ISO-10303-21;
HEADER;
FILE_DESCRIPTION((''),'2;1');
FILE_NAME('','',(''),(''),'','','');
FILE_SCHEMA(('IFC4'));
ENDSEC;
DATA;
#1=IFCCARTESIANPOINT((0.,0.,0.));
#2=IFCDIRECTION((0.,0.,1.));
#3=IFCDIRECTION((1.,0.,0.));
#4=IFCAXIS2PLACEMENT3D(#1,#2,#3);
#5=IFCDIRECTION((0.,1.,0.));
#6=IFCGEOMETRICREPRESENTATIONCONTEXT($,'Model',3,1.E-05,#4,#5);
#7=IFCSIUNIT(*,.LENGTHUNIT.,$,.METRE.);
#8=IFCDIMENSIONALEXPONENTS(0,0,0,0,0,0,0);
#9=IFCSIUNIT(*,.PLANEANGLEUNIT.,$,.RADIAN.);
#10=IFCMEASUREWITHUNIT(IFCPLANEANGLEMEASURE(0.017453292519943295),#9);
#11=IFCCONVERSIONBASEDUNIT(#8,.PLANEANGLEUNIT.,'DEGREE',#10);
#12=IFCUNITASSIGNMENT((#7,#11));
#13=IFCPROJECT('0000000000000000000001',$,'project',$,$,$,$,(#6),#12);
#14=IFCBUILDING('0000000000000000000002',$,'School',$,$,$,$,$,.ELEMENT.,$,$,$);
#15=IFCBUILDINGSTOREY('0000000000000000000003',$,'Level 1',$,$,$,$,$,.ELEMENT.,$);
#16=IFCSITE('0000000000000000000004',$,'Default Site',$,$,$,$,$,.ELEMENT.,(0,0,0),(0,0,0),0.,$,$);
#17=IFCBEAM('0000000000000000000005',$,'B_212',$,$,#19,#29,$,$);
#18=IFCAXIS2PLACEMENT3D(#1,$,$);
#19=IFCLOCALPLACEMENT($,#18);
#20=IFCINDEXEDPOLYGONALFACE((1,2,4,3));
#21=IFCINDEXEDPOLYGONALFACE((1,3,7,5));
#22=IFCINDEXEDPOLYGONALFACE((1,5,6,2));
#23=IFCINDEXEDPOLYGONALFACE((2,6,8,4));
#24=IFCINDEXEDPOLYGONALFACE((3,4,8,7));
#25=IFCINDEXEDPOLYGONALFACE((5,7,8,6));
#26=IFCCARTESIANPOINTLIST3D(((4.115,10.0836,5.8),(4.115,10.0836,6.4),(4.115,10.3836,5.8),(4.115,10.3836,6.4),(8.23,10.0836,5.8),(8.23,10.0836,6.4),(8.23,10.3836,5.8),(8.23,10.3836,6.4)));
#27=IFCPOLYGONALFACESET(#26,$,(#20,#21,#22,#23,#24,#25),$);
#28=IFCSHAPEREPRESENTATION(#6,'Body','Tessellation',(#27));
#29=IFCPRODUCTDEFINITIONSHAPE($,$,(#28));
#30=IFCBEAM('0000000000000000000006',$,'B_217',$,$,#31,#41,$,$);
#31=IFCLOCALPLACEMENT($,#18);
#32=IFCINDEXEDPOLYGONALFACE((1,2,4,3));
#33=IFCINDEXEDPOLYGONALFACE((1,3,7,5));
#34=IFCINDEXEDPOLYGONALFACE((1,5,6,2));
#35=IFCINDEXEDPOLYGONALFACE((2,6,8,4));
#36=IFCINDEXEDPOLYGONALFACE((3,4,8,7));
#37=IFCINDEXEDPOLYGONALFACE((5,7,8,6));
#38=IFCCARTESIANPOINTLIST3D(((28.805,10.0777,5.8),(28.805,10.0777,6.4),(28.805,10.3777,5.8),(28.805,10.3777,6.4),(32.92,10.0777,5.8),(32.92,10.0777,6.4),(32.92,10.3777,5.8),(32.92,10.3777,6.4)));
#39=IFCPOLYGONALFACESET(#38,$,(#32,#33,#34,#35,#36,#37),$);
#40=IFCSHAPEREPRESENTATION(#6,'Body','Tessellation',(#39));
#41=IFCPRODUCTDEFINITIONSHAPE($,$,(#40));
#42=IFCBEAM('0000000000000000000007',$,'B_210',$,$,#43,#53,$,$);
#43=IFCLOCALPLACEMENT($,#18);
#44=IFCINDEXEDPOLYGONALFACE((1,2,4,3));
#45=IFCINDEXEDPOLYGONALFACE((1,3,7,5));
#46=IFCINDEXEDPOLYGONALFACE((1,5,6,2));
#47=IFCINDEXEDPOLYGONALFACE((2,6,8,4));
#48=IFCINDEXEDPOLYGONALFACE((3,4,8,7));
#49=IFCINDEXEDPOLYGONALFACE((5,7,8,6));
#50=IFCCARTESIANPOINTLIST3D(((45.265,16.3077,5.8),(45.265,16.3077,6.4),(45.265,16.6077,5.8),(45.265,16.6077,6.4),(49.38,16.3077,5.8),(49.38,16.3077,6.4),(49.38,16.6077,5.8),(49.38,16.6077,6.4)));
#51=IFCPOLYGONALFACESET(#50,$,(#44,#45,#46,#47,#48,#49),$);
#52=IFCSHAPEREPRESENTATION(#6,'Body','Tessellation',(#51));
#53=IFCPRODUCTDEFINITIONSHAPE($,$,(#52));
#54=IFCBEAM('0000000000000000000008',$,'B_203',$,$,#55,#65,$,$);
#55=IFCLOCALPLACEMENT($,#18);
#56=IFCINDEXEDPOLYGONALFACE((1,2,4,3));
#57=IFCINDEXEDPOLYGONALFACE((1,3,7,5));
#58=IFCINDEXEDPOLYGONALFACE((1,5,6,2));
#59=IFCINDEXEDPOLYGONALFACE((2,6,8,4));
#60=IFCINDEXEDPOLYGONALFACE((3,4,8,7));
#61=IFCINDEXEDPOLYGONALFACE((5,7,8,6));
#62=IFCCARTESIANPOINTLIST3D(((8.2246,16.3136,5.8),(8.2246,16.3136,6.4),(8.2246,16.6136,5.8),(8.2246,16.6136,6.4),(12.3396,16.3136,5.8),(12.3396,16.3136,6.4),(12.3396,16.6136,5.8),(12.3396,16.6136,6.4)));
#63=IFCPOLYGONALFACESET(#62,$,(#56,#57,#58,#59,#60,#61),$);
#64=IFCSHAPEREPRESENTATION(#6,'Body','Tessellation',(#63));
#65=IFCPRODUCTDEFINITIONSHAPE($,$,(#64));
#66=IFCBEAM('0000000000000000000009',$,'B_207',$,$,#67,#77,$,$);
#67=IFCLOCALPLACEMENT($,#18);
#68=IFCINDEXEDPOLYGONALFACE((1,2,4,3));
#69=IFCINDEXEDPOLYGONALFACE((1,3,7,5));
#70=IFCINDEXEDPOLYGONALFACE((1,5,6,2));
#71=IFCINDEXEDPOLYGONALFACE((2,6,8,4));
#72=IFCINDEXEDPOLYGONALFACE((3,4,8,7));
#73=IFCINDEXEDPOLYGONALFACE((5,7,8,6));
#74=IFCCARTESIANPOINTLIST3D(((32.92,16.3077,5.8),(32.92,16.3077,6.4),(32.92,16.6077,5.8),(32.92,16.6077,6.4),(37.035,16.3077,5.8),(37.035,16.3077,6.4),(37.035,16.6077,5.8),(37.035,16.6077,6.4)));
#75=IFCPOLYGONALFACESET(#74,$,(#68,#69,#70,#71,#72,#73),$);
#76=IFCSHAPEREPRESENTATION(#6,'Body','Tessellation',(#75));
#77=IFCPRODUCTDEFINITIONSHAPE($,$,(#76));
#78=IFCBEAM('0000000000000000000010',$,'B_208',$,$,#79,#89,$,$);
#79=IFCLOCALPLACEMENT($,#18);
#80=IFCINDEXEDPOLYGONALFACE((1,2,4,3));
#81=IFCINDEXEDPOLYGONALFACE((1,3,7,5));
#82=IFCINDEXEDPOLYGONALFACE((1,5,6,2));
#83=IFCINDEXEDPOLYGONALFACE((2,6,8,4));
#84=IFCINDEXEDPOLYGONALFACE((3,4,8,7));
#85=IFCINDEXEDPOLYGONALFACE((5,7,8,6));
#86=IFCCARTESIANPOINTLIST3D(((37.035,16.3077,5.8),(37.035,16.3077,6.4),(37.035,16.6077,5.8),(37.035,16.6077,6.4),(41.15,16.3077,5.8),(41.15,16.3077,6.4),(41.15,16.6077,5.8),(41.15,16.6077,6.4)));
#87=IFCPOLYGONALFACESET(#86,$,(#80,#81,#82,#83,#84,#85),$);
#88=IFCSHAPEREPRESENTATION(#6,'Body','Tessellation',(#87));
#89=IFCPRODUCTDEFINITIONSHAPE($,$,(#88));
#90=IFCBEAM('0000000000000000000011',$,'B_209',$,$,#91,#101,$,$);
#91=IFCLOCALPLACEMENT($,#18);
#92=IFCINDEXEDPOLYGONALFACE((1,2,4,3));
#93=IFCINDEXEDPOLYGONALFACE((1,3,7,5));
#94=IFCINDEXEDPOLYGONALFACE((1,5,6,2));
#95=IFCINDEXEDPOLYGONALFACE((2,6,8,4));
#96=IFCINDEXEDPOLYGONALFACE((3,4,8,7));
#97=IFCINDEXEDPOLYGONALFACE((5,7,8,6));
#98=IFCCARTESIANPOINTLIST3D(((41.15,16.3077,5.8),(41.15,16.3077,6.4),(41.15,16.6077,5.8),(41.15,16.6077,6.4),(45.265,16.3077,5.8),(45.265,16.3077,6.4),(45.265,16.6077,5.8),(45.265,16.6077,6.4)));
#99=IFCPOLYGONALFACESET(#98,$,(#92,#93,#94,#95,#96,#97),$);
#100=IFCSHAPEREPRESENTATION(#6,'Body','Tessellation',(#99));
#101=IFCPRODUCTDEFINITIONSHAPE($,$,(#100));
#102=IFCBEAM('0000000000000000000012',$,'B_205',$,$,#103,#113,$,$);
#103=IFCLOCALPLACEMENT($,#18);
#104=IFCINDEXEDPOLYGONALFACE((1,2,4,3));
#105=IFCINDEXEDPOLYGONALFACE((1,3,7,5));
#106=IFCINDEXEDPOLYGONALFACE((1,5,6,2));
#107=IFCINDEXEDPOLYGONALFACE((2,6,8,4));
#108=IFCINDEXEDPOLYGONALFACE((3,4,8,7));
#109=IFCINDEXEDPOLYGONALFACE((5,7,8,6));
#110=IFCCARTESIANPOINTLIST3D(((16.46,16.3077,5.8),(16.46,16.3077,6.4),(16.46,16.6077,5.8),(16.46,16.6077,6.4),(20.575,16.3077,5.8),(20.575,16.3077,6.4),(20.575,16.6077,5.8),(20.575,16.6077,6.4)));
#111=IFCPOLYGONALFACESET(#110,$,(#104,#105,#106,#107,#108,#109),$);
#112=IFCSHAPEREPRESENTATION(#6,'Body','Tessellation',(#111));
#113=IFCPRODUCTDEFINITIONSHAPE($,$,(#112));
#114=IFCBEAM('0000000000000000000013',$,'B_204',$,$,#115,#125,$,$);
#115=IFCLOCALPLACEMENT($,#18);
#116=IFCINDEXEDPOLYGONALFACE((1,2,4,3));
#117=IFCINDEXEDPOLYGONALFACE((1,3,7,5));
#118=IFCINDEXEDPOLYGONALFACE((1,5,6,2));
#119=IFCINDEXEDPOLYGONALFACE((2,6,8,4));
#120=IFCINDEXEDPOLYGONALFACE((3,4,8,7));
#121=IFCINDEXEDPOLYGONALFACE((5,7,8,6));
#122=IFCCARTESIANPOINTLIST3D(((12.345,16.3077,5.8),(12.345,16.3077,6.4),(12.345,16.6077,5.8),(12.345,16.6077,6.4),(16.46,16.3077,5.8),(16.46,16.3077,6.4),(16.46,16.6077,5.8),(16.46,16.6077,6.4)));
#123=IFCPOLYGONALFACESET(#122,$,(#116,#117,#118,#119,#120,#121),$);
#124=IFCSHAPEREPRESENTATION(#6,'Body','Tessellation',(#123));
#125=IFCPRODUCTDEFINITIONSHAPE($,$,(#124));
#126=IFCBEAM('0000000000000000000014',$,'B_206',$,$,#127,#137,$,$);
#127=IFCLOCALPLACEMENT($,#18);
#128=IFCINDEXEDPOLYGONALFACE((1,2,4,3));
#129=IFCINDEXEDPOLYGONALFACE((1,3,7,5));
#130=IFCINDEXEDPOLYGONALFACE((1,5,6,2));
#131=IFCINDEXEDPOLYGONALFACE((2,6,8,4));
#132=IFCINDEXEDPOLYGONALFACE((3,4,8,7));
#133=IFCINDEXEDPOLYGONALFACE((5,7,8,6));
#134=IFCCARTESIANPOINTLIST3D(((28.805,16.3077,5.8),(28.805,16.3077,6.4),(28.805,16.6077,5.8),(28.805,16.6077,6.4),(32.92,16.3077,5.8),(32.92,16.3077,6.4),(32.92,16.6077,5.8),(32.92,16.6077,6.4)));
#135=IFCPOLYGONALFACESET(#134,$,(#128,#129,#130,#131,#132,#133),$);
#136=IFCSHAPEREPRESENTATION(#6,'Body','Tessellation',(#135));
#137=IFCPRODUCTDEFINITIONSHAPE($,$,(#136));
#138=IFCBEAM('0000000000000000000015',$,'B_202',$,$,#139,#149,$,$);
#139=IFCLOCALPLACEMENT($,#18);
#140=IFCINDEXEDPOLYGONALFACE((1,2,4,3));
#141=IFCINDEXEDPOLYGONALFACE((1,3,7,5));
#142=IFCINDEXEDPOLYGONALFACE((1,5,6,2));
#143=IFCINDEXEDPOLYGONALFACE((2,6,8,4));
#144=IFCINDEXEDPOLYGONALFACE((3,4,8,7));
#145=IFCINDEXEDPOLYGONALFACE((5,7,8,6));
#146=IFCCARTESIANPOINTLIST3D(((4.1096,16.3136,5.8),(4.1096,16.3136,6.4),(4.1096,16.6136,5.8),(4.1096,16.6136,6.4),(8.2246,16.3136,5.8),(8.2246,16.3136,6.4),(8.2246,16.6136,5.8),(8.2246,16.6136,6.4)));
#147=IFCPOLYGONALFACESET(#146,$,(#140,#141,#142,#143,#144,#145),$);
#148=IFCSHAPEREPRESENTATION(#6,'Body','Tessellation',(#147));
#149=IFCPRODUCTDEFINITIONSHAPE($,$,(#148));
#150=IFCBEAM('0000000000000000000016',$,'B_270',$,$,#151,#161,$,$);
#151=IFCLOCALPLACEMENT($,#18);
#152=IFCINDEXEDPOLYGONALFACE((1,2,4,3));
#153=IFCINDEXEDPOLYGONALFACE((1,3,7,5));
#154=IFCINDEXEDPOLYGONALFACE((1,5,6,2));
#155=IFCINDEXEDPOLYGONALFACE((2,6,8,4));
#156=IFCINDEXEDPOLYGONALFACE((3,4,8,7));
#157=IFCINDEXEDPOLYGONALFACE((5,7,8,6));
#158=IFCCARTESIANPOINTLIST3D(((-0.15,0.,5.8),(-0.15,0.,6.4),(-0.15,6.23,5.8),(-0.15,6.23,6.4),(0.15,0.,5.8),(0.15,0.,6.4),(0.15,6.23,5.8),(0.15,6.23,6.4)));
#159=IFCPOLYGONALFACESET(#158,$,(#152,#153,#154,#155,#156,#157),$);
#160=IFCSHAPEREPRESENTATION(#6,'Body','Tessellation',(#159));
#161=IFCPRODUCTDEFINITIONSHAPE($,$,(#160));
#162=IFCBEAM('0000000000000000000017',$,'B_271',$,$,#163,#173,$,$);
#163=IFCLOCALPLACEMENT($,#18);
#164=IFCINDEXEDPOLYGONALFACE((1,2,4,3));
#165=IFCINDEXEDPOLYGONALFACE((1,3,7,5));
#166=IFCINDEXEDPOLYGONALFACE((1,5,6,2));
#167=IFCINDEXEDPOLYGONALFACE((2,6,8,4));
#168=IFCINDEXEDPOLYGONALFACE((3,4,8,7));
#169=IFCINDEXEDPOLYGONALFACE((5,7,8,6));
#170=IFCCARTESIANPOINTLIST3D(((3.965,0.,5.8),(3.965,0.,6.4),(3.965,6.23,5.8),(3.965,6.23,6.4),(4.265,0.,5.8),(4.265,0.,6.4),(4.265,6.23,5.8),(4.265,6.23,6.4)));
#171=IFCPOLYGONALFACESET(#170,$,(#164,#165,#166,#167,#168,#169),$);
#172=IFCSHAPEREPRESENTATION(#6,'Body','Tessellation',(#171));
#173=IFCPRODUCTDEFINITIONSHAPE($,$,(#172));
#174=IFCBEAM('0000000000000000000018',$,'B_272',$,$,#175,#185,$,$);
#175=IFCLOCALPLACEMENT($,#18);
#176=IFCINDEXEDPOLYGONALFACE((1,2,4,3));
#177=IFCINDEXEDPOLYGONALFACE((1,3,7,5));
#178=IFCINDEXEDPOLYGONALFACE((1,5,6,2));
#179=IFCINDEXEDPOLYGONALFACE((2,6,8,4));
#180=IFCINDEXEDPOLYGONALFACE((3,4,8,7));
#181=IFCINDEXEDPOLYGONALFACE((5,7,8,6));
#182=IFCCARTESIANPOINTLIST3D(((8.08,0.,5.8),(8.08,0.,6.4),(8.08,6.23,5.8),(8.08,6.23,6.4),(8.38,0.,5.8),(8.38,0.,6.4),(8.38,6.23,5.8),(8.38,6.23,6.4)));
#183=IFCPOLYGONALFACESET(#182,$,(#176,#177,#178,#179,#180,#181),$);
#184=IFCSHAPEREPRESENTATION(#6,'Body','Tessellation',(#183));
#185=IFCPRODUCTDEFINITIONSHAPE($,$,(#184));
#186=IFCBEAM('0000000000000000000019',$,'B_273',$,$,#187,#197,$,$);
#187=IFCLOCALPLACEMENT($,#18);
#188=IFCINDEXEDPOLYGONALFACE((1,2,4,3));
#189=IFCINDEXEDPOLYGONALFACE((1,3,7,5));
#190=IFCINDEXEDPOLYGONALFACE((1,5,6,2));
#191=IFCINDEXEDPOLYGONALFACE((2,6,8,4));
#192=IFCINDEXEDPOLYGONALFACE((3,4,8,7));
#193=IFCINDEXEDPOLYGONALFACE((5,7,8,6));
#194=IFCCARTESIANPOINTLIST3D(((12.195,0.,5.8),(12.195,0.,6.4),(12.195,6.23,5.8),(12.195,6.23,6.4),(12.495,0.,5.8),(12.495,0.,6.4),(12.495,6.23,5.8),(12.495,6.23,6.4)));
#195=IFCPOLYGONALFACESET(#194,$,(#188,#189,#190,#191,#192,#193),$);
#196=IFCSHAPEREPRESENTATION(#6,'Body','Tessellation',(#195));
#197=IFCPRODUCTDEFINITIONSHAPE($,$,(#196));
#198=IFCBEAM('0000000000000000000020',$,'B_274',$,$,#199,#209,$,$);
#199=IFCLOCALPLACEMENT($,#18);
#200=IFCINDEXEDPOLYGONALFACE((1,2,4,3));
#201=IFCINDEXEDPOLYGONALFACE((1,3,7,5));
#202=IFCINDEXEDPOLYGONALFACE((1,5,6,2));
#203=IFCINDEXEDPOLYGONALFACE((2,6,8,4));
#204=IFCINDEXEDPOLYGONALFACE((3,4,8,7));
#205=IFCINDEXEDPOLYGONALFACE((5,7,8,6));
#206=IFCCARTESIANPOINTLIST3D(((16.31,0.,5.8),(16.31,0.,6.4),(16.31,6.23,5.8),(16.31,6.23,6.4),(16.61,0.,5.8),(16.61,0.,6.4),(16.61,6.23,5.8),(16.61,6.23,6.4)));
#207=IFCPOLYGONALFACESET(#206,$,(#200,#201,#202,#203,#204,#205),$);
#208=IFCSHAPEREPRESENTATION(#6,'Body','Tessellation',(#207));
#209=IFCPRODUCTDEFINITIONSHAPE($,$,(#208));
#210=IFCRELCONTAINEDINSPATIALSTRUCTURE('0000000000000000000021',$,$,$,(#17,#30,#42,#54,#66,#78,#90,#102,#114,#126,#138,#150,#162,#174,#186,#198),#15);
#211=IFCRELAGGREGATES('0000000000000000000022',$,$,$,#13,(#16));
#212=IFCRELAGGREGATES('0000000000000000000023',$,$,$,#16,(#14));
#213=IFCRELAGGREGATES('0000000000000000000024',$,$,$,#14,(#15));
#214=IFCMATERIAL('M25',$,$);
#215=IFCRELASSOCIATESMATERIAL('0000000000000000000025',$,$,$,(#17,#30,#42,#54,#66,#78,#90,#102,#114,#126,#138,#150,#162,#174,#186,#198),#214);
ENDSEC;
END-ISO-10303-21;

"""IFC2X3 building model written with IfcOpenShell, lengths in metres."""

from ifc_helpers import new_model, entity, si_unit, converted_unit, direction, frame, frame_2d, origin_with_axes, place, context, project, spatial, rectangle, extrude, material, element, save


model = new_model("IFC2X3")

# Units and contexts
model_context = context("Model", 3, precision=1e-05, world=origin_with_axes(), true_north=direction((0.0, 1.0, 0.0)))
ifc_project = project(units=[si_unit("LENGTHUNIT", "METRE"), converted_unit("PLANEANGLEUNIT", "DEGREE", entity("IfcPlaneAngleMeasure", 0.017453292519943295), si_unit("PLANEANGLEUNIT", "RADIAN"), dimensions=[0, 0, 0, 0, 0, 0, 0])], contexts=[model_context])

# Site, building, storey
site = spatial("IfcSite", under=ifc_project, Name="Default Site", CompositionType="ELEMENT", RefLatitude=(0, 0, 0), RefLongitude=(0, 0, 0), RefElevation=0.0)
building = spatial("IfcBuilding", under=site, Name="School", CompositionType="ELEMENT")
storey = spatial("IfcBuildingStorey", under=building, Name="Level 1", CompositionType="ELEMENT")

# Beams
ifc_material = material(Name="M25")
placement = place(None, origin_with_axes())
element("IfcBeam", 1, at=placement, inside=storey, material=ifc_material, Name="B_212", context=model_context, shape_type="SweptSolid", body=[
    extrude(rectangle(XDim=0.3, YDim=0.6, at=frame_2d((0.0, 0.0), x_axis=(0.0, 1.0, 0.0))), frame((4.115, 10.2336, 6.1), z_axis=(1.0, 0.0, 0.0), x_axis=(0.0, 0.0, -1.0)), (0.0, 0.0, 1.0), 4.115),
])
element("IfcBeam", 2, at=placement, inside=storey, material=ifc_material, Name="B_217", context=model_context, shape_type="SweptSolid", body=[
    extrude(rectangle(XDim=0.3, YDim=0.6, at=frame_2d((0.0, 0.0), x_axis=(0.0, 1.0, 0.0))), frame((28.805, 10.2277, 6.1), z_axis=(1.0, 0.0, 0.0), x_axis=(0.0, 0.0, -1.0)), (0.0, 0.0, 1.0), 4.115),
])
element("IfcBeam", 3, at=placement, inside=storey, material=ifc_material, Name="B_210", context=model_context, shape_type="SweptSolid", body=[
    extrude(rectangle(XDim=0.3, YDim=0.6, at=frame_2d((0.0, 0.0), x_axis=(0.0, 1.0, 0.0))), frame((45.265, 16.4577, 6.1), z_axis=(1.0, 0.0, 0.0), x_axis=(0.0, 0.0, -1.0)), (0.0, 0.0, 1.0), 4.115),
])
element("IfcBeam", 4, at=placement, inside=storey, material=ifc_material, Name="B_203", context=model_context, shape_type="SweptSolid", body=[
    extrude(rectangle(XDim=0.3, YDim=0.6, at=frame_2d((0.0, 0.0), x_axis=(0.0, 1.0, 0.0))), frame((8.2246, 16.4636, 6.1), z_axis=(1.0, 0.0, 0.0), x_axis=(0.0, 0.0, -1.0)), (0.0, 0.0, 1.0), 4.115),
])
element("IfcBeam", 5, at=placement, inside=storey, material=ifc_material, Name="B_207", context=model_context, shape_type="SweptSolid", body=[
    extrude(rectangle(XDim=0.3, YDim=0.6, at=frame_2d((0.0, 0.0), x_axis=(0.0, 1.0, 0.0))), frame((32.92, 16.4577, 6.1), z_axis=(1.0, 0.0, 0.0), x_axis=(0.0, 0.0, -1.0)), (0.0, 0.0, 1.0), 4.115),
])
element("IfcBeam", 6, at=placement, inside=storey, material=ifc_material, Name="B_208", context=model_context, shape_type="SweptSolid", body=[
    extrude(rectangle(XDim=0.3, YDim=0.6, at=frame_2d((0.0, 0.0), x_axis=(0.0, 1.0, 0.0))), frame((37.035, 16.4577, 6.1), z_axis=(1.0, 0.0, 0.0), x_axis=(0.0, 0.0, -1.0)), (0.0, 0.0, 1.0), 4.115),
])
element("IfcBeam", 7, at=placement, inside=storey, material=ifc_material, Name="B_209", context=model_context, shape_type="SweptSolid", body=[
    extrude(rectangle(XDim=0.3, YDim=0.6, at=frame_2d((0.0, 0.0), x_axis=(0.0, 1.0, 0.0))), frame((41.15, 16.4577, 6.1), z_axis=(1.0, 0.0, 0.0), x_axis=(0.0, 0.0, -1.0)), (0.0, 0.0, 1.0), 4.115),
])
element("IfcBeam", 8, at=placement, inside=storey, material=ifc_material, Name="B_205", context=model_context, shape_type="SweptSolid", body=[
    extrude(rectangle(XDim=0.3, YDim=0.6, at=frame_2d((0.0, 0.0), x_axis=(0.0, 1.0, 0.0))), frame((16.46, 16.4577, 6.1), z_axis=(1.0, 0.0, 0.0), x_axis=(0.0, 0.0, -1.0)), (0.0, 0.0, 1.0), 4.115),
])
element("IfcBeam", 9, at=placement, inside=storey, material=ifc_material, Name="B_204", context=model_context, shape_type="SweptSolid", body=[
    extrude(rectangle(XDim=0.3, YDim=0.6, at=frame_2d((0.0, 0.0), x_axis=(0.0, 1.0, 0.0))), frame((12.345, 16.4577, 6.1), z_axis=(1.0, 0.0, 0.0), x_axis=(0.0, 0.0, -1.0)), (0.0, 0.0, 1.0), 4.115),
])
element("IfcBeam", 10, at=placement, inside=storey, material=ifc_material, Name="B_206", context=model_context, shape_type="SweptSolid", body=[
    extrude(rectangle(XDim=0.3, YDim=0.6, at=frame_2d((0.0, 0.0), x_axis=(0.0, 1.0, 0.0))), frame((28.805, 16.4577, 6.1), z_axis=(1.0, 0.0, 0.0), x_axis=(0.0, 0.0, -1.0)), (0.0, 0.0, 1.0), 4.115),
])
element("IfcBeam", 11, at=placement, inside=storey, material=ifc_material, Name="B_202", context=model_context, shape_type="SweptSolid", body=[
    extrude(rectangle(XDim=0.3, YDim=0.6, at=frame_2d((0.0, 0.0), x_axis=(0.0, 1.0, 0.0))), frame((4.1096, 16.4636, 6.1), z_axis=(1.0, 0.0, 0.0), x_axis=(0.0, 0.0, -1.0)), (0.0, 0.0, 1.0), 4.115),
])
element("IfcBeam", 12, at=placement, inside=storey, material=ifc_material, Name="B_270", context=model_context, shape_type="SweptSolid", body=[
    extrude(rectangle(XDim=0.3, YDim=0.6, at=frame_2d((0.0, 0.0), x_axis=(0.0, 1.0, 0.0))), frame((0.0, 0.0, 6.1), z_axis=(0.0, 1.0, 0.0), x_axis=(0.0, 0.0, -1.0)), (0.0, 0.0, 1.0), 6.23),
])
element("IfcBeam", 13, at=placement, inside=storey, material=ifc_material, Name="B_271", context=model_context, shape_type="SweptSolid", body=[
    extrude(rectangle(XDim=0.3, YDim=0.6, at=frame_2d((0.0, 0.0), x_axis=(0.0, 1.0, 0.0))), frame((4.115, 0.0, 6.1), z_axis=(0.0, 1.0, 0.0), x_axis=(0.0, 0.0, -1.0)), (0.0, 0.0, 1.0), 6.23),
])
element("IfcBeam", 14, at=placement, inside=storey, material=ifc_material, Name="B_272", context=model_context, shape_type="SweptSolid", body=[
    extrude(rectangle(XDim=0.3, YDim=0.6, at=frame_2d((0.0, 0.0), x_axis=(0.0, 1.0, 0.0))), frame((8.23, 0.0, 6.1), z_axis=(0.0, 1.0, 0.0), x_axis=(0.0, 0.0, -1.0)), (0.0, 0.0, 1.0), 6.23),
])
element("IfcBeam", 15, at=placement, inside=storey, material=ifc_material, Name="B_273", context=model_context, shape_type="SweptSolid", body=[
    extrude(rectangle(XDim=0.3, YDim=0.6, at=frame_2d((0.0, 0.0), x_axis=(0.0, 1.0, 0.0))), frame((12.345, 0.0, 6.1), z_axis=(0.0, 1.0, 0.0), x_axis=(0.0, 0.0, -1.0)), (0.0, 0.0, 1.0), 6.23),
])
element("IfcBeam", 16, at=placement, inside=storey, material=ifc_material, Name="B_274", context=model_context, shape_type="SweptSolid", body=[
    extrude(rectangle(XDim=0.3, YDim=0.6, at=frame_2d((0.0, 0.0), x_axis=(0.0, 1.0, 0.0))), frame((16.46, 0.0, 6.1), z_axis=(0.0, 1.0, 0.0), x_axis=(0.0, 0.0, -1.0)), (0.0, 0.0, 1.0), 6.23),
])

save(model, "model.ifc")
